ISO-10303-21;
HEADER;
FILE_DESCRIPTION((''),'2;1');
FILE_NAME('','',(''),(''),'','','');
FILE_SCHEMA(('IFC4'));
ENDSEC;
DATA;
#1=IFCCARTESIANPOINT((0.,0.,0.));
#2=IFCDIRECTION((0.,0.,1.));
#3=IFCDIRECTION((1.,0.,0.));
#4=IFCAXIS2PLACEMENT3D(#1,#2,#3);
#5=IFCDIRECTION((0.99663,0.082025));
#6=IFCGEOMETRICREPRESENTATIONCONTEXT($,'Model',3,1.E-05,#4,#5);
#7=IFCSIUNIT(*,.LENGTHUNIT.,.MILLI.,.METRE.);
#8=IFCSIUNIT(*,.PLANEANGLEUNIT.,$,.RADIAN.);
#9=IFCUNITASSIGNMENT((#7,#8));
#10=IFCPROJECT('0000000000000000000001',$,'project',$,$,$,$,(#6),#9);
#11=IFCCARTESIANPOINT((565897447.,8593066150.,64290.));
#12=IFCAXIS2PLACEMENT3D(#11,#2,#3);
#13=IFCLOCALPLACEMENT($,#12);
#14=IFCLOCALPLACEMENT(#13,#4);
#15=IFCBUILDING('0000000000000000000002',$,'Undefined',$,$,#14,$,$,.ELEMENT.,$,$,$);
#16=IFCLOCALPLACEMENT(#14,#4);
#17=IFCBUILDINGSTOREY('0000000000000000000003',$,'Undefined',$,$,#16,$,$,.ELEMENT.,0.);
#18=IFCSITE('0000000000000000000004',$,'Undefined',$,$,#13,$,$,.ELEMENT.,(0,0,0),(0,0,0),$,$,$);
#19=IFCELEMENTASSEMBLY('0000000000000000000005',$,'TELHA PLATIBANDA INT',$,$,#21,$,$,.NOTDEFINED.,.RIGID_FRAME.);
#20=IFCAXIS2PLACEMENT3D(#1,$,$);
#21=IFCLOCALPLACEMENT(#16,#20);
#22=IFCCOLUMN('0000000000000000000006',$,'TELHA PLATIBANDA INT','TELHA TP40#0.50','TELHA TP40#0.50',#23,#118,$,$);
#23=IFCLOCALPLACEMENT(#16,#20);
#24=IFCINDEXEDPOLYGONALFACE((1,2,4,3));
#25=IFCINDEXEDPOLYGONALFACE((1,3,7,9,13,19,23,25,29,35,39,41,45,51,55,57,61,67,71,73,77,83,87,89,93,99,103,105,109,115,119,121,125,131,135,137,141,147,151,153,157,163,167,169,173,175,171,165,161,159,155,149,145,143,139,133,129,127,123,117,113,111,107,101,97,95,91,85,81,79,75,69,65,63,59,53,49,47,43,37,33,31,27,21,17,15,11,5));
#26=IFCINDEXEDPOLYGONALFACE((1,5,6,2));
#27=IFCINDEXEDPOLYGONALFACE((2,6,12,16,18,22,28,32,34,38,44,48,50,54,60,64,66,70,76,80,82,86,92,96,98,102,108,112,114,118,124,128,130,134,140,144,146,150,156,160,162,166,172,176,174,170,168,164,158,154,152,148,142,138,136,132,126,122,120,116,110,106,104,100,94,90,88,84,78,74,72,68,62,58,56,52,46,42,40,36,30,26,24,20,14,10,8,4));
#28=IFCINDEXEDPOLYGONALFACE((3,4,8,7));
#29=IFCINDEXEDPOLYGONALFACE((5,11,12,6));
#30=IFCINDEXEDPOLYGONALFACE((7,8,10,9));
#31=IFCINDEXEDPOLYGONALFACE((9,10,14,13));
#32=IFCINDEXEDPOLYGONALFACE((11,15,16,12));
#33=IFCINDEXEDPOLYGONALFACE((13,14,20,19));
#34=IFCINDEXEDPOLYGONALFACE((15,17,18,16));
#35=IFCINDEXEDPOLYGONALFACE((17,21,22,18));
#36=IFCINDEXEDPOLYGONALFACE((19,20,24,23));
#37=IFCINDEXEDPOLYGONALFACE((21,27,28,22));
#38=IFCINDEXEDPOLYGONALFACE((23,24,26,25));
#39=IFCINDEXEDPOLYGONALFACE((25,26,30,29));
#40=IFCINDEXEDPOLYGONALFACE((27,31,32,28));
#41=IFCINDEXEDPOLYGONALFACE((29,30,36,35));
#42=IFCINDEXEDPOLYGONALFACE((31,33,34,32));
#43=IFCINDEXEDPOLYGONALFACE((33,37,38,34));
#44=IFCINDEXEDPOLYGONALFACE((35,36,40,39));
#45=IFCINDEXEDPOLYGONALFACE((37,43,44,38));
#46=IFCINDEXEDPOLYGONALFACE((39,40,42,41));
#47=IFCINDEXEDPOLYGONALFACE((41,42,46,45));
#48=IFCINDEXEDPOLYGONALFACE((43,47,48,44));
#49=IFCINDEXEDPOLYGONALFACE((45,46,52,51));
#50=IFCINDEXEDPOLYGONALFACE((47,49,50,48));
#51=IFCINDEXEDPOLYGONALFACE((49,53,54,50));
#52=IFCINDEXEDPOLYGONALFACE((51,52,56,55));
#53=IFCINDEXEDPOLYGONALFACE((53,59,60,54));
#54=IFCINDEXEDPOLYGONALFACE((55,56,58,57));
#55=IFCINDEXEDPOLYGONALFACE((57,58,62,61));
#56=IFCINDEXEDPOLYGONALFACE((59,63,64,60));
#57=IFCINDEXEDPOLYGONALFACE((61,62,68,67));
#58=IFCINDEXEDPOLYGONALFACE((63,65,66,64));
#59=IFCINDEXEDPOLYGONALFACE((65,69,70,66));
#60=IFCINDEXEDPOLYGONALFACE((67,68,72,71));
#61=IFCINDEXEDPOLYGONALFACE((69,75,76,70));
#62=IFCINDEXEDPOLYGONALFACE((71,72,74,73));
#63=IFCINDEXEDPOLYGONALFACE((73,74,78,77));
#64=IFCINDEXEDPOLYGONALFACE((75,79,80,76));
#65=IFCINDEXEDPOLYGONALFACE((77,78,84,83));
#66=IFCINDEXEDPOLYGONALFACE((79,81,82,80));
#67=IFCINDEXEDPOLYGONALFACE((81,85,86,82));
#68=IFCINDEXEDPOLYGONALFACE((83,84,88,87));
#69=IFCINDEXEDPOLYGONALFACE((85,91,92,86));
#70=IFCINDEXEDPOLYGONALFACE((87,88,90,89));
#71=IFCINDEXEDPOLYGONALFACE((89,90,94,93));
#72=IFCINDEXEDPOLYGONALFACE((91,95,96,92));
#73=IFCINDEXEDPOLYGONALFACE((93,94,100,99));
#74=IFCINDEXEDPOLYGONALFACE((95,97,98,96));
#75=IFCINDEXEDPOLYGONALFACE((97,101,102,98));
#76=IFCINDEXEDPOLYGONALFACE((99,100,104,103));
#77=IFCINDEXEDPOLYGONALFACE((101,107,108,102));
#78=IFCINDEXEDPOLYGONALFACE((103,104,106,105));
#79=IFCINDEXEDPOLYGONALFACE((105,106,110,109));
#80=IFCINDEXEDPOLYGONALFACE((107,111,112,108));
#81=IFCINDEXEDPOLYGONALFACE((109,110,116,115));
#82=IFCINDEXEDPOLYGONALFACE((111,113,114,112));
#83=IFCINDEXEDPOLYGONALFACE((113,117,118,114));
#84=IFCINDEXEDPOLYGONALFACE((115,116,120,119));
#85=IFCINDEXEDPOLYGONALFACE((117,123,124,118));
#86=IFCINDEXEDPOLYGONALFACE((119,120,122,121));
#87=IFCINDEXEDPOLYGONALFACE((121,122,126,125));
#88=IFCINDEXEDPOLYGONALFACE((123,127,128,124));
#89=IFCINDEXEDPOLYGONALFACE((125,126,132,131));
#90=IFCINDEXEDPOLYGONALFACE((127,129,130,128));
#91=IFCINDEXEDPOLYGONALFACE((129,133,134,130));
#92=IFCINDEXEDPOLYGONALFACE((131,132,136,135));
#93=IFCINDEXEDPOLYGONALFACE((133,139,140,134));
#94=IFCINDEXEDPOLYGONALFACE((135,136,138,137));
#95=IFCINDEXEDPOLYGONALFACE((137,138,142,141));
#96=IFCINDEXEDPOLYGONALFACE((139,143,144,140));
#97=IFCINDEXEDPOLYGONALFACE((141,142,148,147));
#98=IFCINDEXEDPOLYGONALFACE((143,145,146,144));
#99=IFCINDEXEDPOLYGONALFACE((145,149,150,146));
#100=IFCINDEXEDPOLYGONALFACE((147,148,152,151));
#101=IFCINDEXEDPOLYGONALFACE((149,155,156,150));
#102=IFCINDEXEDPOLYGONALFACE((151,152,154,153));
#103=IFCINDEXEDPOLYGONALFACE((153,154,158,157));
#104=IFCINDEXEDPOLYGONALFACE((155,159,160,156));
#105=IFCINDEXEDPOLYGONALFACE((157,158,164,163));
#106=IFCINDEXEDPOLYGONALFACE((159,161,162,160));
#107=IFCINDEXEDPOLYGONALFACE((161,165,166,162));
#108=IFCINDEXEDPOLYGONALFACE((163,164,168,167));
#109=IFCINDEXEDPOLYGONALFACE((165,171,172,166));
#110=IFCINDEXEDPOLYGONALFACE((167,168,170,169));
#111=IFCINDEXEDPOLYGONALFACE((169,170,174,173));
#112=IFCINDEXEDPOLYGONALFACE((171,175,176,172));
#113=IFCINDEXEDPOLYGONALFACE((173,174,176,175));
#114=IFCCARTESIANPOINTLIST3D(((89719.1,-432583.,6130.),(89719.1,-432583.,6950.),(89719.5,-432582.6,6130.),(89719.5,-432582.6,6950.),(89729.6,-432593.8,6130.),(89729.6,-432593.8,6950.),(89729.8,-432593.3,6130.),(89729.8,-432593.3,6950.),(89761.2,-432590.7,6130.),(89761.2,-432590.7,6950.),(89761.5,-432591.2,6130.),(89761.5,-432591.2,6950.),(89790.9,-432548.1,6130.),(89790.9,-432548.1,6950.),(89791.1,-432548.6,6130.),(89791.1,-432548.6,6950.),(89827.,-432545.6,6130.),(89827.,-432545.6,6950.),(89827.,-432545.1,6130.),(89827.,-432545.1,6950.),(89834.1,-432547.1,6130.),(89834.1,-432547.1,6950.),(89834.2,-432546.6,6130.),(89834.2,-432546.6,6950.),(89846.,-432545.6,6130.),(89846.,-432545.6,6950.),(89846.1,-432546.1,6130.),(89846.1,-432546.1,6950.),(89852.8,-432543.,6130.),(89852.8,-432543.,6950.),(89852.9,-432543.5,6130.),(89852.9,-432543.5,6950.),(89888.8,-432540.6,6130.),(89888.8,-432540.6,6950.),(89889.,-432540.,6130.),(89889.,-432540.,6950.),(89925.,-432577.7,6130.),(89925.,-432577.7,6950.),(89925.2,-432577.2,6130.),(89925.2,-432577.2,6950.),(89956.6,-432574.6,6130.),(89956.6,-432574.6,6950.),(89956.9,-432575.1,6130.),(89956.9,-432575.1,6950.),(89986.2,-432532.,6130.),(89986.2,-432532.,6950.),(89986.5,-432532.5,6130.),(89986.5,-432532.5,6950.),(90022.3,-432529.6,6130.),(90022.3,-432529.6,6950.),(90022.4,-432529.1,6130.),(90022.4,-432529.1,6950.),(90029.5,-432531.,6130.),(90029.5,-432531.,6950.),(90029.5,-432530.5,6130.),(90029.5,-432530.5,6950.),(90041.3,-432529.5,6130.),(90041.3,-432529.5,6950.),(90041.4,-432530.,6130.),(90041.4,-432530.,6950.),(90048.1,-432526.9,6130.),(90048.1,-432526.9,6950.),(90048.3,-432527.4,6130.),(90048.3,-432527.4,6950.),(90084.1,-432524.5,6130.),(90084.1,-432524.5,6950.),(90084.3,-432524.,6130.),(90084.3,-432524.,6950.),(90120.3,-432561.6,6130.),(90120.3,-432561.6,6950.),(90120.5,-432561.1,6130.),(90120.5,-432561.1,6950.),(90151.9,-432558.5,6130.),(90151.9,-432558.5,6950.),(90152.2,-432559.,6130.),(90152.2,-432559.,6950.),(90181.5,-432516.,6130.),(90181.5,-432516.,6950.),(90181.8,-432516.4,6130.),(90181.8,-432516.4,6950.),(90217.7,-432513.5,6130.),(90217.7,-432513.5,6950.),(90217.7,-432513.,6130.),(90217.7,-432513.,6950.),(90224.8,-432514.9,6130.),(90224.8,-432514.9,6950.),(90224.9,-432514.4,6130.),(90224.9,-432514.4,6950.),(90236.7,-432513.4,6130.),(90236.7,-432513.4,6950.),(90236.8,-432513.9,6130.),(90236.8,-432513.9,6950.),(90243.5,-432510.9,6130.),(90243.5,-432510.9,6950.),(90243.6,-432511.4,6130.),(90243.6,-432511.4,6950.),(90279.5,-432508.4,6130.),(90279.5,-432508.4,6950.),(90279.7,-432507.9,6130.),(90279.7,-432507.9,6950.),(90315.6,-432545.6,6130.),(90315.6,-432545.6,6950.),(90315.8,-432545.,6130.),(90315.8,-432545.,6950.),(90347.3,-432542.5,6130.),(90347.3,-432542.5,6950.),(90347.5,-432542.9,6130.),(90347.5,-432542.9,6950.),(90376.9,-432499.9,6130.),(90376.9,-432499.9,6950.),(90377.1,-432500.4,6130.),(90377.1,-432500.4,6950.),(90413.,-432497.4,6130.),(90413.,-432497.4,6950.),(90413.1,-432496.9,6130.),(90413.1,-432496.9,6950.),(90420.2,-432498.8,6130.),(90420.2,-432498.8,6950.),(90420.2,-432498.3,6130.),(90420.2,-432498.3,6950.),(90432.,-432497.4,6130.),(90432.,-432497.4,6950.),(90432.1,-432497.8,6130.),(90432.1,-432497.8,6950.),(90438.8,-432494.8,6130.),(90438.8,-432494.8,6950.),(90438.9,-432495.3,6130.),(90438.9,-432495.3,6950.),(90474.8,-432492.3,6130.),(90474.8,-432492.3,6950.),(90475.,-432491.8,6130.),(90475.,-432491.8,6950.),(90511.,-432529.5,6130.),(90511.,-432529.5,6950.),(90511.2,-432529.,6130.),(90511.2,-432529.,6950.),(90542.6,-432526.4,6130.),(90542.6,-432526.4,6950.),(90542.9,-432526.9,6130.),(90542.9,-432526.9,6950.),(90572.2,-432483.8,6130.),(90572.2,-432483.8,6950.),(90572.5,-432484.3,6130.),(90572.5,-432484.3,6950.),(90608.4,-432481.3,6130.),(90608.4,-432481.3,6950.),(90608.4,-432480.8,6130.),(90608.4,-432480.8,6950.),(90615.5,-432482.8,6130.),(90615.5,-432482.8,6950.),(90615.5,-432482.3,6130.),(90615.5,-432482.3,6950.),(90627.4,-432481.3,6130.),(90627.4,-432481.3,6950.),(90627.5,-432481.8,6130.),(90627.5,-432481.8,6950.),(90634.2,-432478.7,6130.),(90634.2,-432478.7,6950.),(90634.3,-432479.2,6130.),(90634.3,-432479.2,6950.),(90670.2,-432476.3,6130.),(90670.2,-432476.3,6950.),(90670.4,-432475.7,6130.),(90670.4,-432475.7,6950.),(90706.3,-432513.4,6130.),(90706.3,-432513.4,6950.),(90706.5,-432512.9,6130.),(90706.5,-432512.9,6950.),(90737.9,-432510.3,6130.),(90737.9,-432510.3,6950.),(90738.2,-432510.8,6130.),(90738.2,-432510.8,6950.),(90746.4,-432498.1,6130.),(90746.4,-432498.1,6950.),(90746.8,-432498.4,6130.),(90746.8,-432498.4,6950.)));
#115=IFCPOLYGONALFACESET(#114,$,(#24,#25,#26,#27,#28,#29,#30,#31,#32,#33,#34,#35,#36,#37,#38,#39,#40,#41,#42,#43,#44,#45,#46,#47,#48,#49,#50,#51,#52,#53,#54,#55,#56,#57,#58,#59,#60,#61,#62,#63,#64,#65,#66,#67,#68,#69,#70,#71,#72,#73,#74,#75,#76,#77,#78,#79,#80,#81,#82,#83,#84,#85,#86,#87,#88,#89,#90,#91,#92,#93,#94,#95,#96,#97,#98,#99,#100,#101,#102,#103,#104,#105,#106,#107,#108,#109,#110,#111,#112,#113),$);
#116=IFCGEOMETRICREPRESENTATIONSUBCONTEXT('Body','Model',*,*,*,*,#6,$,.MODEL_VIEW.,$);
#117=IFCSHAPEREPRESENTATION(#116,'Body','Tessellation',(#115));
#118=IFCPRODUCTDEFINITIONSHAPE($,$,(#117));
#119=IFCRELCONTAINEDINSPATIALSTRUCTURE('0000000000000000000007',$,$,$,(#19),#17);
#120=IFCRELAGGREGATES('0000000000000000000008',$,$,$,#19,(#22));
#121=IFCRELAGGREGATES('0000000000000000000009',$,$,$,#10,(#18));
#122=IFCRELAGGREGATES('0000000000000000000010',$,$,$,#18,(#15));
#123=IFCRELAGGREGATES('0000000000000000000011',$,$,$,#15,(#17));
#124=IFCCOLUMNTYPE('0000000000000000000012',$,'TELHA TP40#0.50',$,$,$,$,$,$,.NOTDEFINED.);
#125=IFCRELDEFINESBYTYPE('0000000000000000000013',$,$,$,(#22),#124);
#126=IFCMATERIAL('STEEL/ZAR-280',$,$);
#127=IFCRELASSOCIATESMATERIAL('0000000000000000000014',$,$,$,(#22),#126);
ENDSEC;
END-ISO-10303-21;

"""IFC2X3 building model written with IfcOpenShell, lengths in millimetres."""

from ifc_helpers import new_model, si_unit, direction, frame, origin_with_axes, place, context, subcontext, project, spatial, polyline, outline, extrude, material, type_object, element, aggregate, save


model = new_model("IFC2X3")

# Units and contexts
model_context = context("Model", 3, precision=1e-05, world=origin_with_axes(), true_north=direction((0.99663, 0.082025)))
body_context = subcontext(model_context, "Body", "Model", "MODEL_VIEW")
ifc_project = project(units=[si_unit("LENGTHUNIT", "METRE", prefix="MILLI"), si_unit("PLANEANGLEUNIT", "RADIAN")], contexts=[model_context])

# Site, building, storey
site_placement = place(None, frame((565897447.0, 8593066150.0, 64290.0), z_axis=(0.0, 0.0, 1.0), x_axis=(1.0, 0.0, 0.0)))
site = spatial("IfcSite", under=ifc_project, at=site_placement, Name="Undefined", CompositionType="ELEMENT", RefLatitude=(0, 0, 0), RefLongitude=(0, 0, 0))
building_placement = place(site_placement, origin_with_axes())
building = spatial("IfcBuilding", under=site, at=building_placement, Name="Undefined", CompositionType="ELEMENT")
storey_placement = place(building_placement, origin_with_axes())
storey = spatial("IfcBuildingStorey", under=building, at=storey_placement, Name="Undefined", CompositionType="ELEMENT", Elevation=0.0)

# Element assembly, column
assembly_1_placement = place(storey_placement, origin_with_axes())
assembly_1 = element("IfcElementAssembly", 1, at=assembly_1_placement, inside=storey, Name="TELHA PLATIBANDA INT", AssemblyPlace="NOTDEFINED", PredefinedType="RIGID_FRAME")
ifc_material_1 = material(Name="STEEL/ZAR-280")
column_type = type_object("IfcColumnType", Name="TELHA TP40#0.50", PredefinedType="NOTDEFINED")
column_1_placement = place(assembly_1_placement, frame((90232.5, -432532.1, 6130.0), z_axis=(0.0, 0.0, 1.0), x_axis=(0.082025, -0.99663, 0.0)))
column_1 = element("IfcColumn", 2, at=column_1_placement, type_object=column_type, material=ifc_material_1, Name="TELHA PLATIBANDA INT", Description="TELHA TP40#0.50", ObjectType="TELHA TP40#0.50", context=body_context, shape_type="SweptSolid", body=[
    extrude(outline(polyline([(440.8, -19.8), (473.8, 20.2), (505.8, 20.2), (515.4, 8.6), (515.0, 8.3), (505.6, 19.8), (474.0, 19.8), (441.0, -20.2), (404.7, -20.2), (397.7, -18.2), (385.9, -18.2), (378.9, -20.2), (342.6, -20.2), (309.6, 19.8), (278.0, 19.8), (245.0, -20.2), (208.7, -20.2), (201.7, -18.2), (189.9, -18.2), (182.9, -20.2), (146.6, -20.2), (113.6, 19.8), (82.0, 19.8), (49.0, -20.2), (12.7, -20.2), (5.7, -18.2), (-6.1, -18.2), (-13.1, -20.2), (-49.4, -20.2), (-82.4, 19.8), (-114.0, 19.8), (-147.0, -20.2), (-183.3, -20.2), (-190.3, -18.2), (-202.1, -18.2), (-209.1, -20.2), (-245.4, -20.2), (-278.4, 19.8), (-310.0, 19.8), (-343.0, -20.2), (-379.3, -20.2), (-386.3, -18.2), (-398.1, -18.2), (-405.1, -20.2), (-441.4, -20.2), (-474.4, 19.8), (-506.0, 19.8), (-515.4, 8.3), (-515.8, 8.6), (-506.2, 20.2), (-474.2, 20.2), (-441.2, -19.8), (-405.2, -19.8), (-398.2, -17.8), (-386.2, -17.8), (-379.2, -19.8), (-343.2, -19.8), (-310.2, 20.2), (-278.2, 20.2), (-245.2, -19.8), (-209.2, -19.8), (-202.2, -17.8), (-190.2, -17.8), (-183.2, -19.8), (-147.2, -19.8), (-114.2, 20.2), (-82.2, 20.2), (-49.2, -19.8), (-13.2, -19.8), (-6.2, -17.8), (5.8, -17.8), (12.8, -19.8), (48.8, -19.8), (81.8, 20.2), (113.8, 20.2), (146.8, -19.8), (182.8, -19.8), (189.8, -17.8), (201.8, -17.8), (208.8, -19.8), (244.8, -19.8), (277.8, 20.2), (309.8, 20.2), (342.8, -19.8), (378.8, -19.8), (385.8, -17.8), (397.8, -17.8), (404.8, -19.8), (440.8, -19.8)])), frame((0.0, 0.0, 820.0), z_axis=(0.0, 0.0, -1.0), x_axis=(0.0, 1.0, 0.0)), (0.0, 0.0, 1.0), 820.0),
])
aggregate(assembly_1, [column_1])

save(model, "model.ifc")
